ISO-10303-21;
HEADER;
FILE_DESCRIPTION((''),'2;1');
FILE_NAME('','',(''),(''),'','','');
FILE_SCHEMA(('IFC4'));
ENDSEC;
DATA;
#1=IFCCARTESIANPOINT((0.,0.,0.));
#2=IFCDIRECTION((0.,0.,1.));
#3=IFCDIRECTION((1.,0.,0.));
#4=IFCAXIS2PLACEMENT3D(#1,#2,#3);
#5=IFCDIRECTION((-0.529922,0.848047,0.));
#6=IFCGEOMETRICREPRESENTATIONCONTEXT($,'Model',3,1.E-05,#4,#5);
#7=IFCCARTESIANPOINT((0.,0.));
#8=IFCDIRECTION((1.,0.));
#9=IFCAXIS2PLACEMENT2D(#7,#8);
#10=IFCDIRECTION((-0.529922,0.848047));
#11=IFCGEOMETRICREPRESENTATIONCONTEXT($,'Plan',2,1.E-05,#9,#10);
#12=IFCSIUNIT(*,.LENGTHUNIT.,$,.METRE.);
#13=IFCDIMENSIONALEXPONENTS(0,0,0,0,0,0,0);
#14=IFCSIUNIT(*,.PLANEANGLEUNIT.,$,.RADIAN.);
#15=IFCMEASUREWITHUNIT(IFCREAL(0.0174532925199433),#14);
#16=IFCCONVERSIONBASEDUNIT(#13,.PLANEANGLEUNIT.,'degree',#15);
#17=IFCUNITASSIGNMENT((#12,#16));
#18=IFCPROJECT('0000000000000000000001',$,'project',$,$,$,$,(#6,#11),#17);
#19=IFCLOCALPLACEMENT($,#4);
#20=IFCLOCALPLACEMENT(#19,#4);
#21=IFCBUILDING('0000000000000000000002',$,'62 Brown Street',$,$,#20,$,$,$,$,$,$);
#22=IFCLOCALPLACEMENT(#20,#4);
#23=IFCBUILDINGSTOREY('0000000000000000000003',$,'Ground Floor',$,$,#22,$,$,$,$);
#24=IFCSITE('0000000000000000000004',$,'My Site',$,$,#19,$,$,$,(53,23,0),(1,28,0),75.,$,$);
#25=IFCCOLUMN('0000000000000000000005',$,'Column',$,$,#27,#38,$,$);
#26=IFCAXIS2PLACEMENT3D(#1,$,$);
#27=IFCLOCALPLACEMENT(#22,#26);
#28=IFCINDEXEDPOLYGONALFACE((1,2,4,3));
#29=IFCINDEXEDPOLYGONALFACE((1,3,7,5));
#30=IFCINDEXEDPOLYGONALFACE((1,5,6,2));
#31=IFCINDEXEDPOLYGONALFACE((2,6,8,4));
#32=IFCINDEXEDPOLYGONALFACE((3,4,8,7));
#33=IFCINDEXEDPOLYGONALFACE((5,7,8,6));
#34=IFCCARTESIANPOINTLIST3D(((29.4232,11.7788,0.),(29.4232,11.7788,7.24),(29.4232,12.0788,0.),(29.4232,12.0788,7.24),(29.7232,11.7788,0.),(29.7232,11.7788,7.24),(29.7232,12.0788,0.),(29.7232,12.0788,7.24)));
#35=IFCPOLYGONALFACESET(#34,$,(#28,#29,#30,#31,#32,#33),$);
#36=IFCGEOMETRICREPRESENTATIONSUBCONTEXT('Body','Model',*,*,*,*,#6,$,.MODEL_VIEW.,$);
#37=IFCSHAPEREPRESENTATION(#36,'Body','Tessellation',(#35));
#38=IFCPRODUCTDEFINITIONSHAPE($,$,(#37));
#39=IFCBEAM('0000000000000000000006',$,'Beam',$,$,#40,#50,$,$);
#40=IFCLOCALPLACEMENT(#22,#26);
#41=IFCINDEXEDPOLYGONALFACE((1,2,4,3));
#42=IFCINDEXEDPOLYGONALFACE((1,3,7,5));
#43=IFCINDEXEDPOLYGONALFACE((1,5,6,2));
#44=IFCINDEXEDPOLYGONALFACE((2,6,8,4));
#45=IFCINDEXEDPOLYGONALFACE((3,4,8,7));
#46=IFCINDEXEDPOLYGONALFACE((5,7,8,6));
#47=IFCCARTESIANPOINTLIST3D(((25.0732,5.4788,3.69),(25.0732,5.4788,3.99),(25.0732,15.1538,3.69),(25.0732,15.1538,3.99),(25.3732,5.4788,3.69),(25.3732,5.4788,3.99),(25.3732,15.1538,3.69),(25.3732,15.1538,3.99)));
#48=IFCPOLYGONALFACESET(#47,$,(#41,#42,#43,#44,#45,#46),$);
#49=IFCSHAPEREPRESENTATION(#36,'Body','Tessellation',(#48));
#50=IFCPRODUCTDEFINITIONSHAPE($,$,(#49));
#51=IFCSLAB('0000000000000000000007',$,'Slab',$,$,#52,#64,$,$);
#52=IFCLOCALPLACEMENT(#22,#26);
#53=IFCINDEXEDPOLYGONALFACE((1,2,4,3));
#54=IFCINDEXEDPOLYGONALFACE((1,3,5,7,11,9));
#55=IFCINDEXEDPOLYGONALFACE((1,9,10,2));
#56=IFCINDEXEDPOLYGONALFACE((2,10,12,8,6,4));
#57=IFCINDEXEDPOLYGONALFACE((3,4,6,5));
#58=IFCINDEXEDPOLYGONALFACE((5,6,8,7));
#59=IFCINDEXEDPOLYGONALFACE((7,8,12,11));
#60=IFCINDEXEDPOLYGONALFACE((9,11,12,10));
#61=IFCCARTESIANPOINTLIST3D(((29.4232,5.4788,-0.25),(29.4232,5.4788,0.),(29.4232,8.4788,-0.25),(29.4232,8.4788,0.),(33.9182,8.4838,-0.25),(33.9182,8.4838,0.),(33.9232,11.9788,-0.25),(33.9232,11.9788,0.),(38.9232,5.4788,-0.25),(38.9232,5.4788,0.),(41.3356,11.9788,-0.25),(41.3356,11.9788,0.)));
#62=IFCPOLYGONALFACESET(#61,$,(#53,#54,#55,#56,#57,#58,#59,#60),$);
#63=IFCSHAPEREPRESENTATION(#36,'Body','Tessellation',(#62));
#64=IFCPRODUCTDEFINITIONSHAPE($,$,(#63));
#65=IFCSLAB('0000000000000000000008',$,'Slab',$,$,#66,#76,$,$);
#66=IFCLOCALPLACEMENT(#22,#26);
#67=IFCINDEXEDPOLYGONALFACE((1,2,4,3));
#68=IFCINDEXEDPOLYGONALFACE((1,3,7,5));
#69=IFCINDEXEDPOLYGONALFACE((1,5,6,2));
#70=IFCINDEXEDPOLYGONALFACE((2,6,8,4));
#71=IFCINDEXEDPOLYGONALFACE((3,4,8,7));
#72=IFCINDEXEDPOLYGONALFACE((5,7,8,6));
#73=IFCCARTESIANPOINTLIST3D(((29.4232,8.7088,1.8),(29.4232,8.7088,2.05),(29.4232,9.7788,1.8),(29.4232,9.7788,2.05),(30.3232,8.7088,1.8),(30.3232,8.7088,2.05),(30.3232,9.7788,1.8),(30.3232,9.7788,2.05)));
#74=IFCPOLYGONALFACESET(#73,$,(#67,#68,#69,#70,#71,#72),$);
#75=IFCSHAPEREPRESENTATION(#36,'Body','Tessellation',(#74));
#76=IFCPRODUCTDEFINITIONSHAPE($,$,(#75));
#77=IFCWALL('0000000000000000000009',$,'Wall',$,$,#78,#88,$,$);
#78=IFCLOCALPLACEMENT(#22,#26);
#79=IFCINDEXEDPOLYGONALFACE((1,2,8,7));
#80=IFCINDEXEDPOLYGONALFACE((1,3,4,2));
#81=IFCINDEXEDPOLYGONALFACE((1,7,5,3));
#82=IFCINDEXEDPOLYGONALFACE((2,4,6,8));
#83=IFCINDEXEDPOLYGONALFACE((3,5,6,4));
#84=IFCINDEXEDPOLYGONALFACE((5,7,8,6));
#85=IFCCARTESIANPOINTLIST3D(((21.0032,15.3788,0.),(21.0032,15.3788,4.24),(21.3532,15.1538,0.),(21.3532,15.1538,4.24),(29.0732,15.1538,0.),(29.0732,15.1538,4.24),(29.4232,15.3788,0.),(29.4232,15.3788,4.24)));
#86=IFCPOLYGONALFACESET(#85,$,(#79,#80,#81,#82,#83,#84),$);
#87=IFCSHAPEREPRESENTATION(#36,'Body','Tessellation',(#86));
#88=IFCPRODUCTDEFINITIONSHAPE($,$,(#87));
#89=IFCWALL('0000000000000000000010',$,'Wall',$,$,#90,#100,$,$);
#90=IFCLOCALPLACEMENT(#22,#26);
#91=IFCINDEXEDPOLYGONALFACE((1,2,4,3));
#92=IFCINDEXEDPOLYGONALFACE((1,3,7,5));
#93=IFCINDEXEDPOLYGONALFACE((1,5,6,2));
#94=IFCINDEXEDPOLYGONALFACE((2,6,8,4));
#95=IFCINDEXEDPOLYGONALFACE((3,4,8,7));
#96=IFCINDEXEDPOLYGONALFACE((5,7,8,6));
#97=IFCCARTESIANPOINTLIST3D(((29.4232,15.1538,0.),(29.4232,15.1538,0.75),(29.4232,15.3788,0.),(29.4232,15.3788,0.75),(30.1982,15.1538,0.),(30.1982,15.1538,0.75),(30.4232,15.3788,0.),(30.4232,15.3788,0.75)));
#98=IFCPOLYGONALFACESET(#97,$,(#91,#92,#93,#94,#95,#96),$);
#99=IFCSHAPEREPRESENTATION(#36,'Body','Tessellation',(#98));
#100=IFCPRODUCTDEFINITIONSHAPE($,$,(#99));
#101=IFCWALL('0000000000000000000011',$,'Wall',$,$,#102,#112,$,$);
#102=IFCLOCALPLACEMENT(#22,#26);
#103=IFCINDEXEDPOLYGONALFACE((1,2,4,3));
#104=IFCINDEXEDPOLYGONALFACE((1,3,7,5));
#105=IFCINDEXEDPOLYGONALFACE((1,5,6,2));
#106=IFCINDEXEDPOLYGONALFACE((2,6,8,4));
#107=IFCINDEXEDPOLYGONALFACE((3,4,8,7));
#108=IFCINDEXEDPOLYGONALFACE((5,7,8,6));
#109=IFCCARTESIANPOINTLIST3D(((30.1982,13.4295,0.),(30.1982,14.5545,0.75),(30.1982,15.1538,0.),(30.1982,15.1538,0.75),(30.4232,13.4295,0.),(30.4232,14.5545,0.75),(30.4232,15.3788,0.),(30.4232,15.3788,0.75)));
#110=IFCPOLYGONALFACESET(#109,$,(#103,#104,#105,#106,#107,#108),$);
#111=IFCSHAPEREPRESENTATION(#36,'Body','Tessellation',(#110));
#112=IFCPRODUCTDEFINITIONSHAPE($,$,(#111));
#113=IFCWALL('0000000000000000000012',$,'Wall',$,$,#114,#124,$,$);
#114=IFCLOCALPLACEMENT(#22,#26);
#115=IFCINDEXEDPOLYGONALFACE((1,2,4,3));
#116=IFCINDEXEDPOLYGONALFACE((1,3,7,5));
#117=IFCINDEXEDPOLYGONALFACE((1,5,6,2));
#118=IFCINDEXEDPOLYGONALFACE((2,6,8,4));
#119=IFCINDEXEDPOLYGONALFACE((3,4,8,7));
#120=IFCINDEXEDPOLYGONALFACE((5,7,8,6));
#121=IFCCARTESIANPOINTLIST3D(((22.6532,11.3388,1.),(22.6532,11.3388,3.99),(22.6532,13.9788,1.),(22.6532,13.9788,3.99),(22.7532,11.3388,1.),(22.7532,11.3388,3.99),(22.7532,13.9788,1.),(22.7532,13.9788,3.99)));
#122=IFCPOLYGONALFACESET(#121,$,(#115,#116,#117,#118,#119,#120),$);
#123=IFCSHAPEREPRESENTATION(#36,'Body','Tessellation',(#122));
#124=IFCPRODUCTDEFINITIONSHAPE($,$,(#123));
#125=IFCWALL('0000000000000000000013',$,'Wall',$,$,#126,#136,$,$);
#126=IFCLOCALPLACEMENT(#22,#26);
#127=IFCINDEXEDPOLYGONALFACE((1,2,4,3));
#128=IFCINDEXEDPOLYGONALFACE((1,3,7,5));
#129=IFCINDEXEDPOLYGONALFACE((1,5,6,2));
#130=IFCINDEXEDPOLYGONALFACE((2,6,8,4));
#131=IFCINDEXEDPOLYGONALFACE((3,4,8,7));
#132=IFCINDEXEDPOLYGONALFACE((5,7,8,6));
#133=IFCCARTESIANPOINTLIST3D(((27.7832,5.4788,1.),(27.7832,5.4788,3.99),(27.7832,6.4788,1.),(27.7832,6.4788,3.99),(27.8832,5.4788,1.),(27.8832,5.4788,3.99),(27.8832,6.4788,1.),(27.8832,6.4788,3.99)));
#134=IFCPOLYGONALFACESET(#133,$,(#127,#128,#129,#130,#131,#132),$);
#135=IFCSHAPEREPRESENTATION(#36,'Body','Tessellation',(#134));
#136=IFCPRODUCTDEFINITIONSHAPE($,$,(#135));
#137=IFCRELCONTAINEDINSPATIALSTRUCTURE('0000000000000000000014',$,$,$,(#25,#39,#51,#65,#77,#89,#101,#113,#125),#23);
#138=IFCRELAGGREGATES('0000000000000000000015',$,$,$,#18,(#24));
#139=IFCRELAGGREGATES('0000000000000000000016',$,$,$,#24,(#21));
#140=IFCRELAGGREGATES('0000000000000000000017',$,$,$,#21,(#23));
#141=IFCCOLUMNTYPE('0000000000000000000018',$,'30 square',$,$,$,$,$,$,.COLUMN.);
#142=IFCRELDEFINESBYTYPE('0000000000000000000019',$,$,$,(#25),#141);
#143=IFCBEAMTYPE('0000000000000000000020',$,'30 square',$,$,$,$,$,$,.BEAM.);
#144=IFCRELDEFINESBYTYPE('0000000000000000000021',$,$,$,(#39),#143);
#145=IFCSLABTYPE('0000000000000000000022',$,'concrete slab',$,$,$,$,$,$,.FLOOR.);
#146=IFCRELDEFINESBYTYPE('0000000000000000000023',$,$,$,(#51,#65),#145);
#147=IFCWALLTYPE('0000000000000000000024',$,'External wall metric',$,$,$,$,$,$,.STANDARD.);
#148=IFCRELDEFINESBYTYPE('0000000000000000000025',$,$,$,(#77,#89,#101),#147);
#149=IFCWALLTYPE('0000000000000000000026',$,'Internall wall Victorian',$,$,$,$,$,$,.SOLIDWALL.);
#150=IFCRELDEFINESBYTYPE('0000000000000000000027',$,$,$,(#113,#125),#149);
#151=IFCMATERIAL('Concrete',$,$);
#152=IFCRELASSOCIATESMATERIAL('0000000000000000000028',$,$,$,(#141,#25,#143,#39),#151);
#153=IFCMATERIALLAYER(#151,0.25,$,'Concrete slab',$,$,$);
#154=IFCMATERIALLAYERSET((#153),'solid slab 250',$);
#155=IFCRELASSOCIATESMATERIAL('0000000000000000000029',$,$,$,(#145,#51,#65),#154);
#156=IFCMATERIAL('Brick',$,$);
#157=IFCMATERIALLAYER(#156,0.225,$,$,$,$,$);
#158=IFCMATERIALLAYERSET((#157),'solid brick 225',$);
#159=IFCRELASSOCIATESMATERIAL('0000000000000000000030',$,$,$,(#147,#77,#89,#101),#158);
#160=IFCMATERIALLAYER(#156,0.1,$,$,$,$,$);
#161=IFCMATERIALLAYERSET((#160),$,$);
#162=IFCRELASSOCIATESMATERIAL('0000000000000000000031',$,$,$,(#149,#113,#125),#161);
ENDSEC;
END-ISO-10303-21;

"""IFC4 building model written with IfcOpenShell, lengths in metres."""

from ifc_helpers import new_model, entity, si_unit, converted_unit, direction, frame, origin_with_axes, origin_2d_with_axis, place, context, subcontext, project, spatial, line, indexed_curve, rectangle, outline, extrude, clip, halfspace, material, layer, layer_set, layer_usage, material_profile, profile_set, profile_usage, type_object, element, save


model = new_model("IFC4")

# Units and contexts
model_context = context("Model", 3, precision=1e-05, world=origin_with_axes(), true_north=direction((-0.529922, 0.848047, 0.0)))
plan_context = context("Plan", 2, precision=1e-05, world=origin_2d_with_axis(), true_north=direction((-0.529922, 0.848047)))
body_context = subcontext(model_context, "Body", "Model", "MODEL_VIEW")
ifc_project = project(units=[si_unit("LENGTHUNIT", "METRE"), converted_unit("PLANEANGLEUNIT", "degree", entity("IfcReal", 0.0174532925199433), si_unit("PLANEANGLEUNIT", "RADIAN"), dimensions=[0, 0, 0, 0, 0, 0, 0])], contexts=[model_context, plan_context])

# Site, building, storey
site_placement = place(None, origin_with_axes())
site = spatial("IfcSite", under=ifc_project, at=site_placement, Name="My Site", RefLatitude=(53, 23, 0), RefLongitude=(1, 28, 0), RefElevation=75.0)
building_placement = place(site_placement, origin_with_axes())
building = spatial("IfcBuilding", under=site, at=building_placement, Name="62 Brown Street")
storey_placement = place(building_placement, origin_with_axes())
storey = spatial("IfcBuildingStorey", under=building, at=storey_placement, Name="Ground Floor")

# Column
ifc_material_1 = material(Name="Concrete")
ifc_material_profile_1 = material_profile(ifc_material_1, rectangle(XDim=0.3, YDim=0.3))
ifc_profile_set_1 = profile_set([ifc_material_profile_1])
ifc_profile_usage_1 = profile_usage(ifc_profile_set_1, cardinal=5)
column_type = type_object("IfcColumnType", Name="30 square", PredefinedType="COLUMN", material=ifc_profile_set_1)
column_1_placement = place(storey_placement, frame((29.5732, 11.9288, 0.0), z_axis=(0.0, 0.0, 1.0), x_axis=(1.0, 0.0, 0.0)))
element("IfcColumn", 1, at=column_1_placement, inside=storey, type_object=column_type, material=ifc_profile_usage_1, Name="Column", context=body_context, shape_type="SweptSolid", body=[
    extrude(rectangle(XDim=0.3, YDim=0.3), origin_with_axes(), (0.0, 0.0, 1.0), 7.24),
])

# Beam
ifc_material_profile_2 = material_profile(ifc_material_1, rectangle(XDim=0.3, YDim=0.3))
ifc_profile_set_2 = profile_set([ifc_material_profile_2])
ifc_profile_usage_2 = profile_usage(ifc_profile_set_2, cardinal=5)
beam_type = type_object("IfcBeamType", Name="30 square", PredefinedType="BEAM", material=ifc_profile_set_2)
beam_placement = place(storey_placement, frame((25.2232, 5.4788, 3.84), z_axis=(0.0, 1.0, 0.0), x_axis=(-1.0, 0.0, 0.0)))
element("IfcBeam", 2, at=beam_placement, inside=storey, type_object=beam_type, material=ifc_profile_usage_2, Name="Beam", context=body_context, shape_type="SweptSolid", body=[
    extrude(rectangle(XDim=0.3, YDim=0.3), origin_with_axes(), (0.0, 0.0, 1.0), 9.675),
])

# Slabs
ifc_layer_1 = layer(ifc_material_1, 0.25, Name="Concrete slab")
ifc_layer_set_1 = layer_set([ifc_layer_1], Name="solid slab 250")
ifc_layer_usage_1 = layer_usage(ifc_layer_set_1, "AXIS3", "POSITIVE", 0.0)
slab_type = type_object("IfcSlabType", Name="concrete slab", PredefinedType="FLOOR", material=ifc_layer_set_1)
slab_1_placement = place(storey_placement, frame((29.4232, 5.4788, -0.25), z_axis=(0.0, 0.0, 1.0), x_axis=(1.0, 0.0, 0.0)))
element("IfcSlab", 3, at=slab_1_placement, inside=storey, type_object=slab_type, material=ifc_layer_usage_1, Name="Slab", context=body_context, shape_type="SweptSolid", body=[
    extrude(outline(indexed_curve([(0.0, 0.0), (9.5, 0.0), (11.9124, 6.5), (0.0, 3.0), (4.5, 6.5), (4.495, 3.005)], segments=[line(1, 2), line(2, 3), line(3, 5), line(5, 6), line(6, 4), line(4, 1)], self_intersect=False)), None, (0.0, 0.0, 1.0), 0.25),
])
ifc_layer_usage_2 = layer_usage(ifc_layer_set_1, "AXIS3", "POSITIVE", 0.0)
slab_2_placement = place(storey_placement, frame((29.4232, 8.7088, 1.8), z_axis=(0.0, 0.0, 1.0), x_axis=(1.0, 0.0, 0.0)))
element("IfcSlab", 4, at=slab_2_placement, inside=storey, type_object=slab_type, material=ifc_layer_usage_2, Name="Slab", context=body_context, shape_type="SweptSolid", body=[
    extrude(outline(indexed_curve([(0.9, 1.07), (0.9, 0.0), (0.0, 0.0), (0.0, 1.07)], segments=[line(3, 2), line(2, 1), line(1, 4), line(4, 3)], self_intersect=False)), None, (0.0, 0.0, 1.0), 0.25),
])

# Walls
ifc_material_2 = material(Name="Brick")
ifc_layer_2 = layer(ifc_material_2, 0.225)
ifc_layer_set_2 = layer_set([ifc_layer_2], Name="solid brick 225")
wall_type_1 = type_object("IfcWallType", Name="External wall metric", PredefinedType="STANDARD", material=ifc_layer_set_2)
ifc_layer_usage_3 = layer_usage(ifc_layer_set_2, "AXIS2", "POSITIVE", 0.0)
wall_1_placement = place(storey_placement, frame((29.4232, 15.3788, 0.0), z_axis=(0.0, 0.0, 1.0), x_axis=(-1.0, 0.0, 0.0)))
element("IfcWall", 5, at=wall_1_placement, inside=storey, type_object=wall_type_1, material=ifc_layer_usage_3, Name="Wall", context=body_context, shape_type="Clipping", body=[
    clip(clip(extrude(outline(indexed_curve([(0.0, 0.0), (0.0, 0.225), (8.42, 0.225), (8.42, 0.0), (0.0, 0.0)], self_intersect=False)), origin_with_axes(), (0.0, 0.0, 1.0), 4.24), halfspace(frame((8.42, 0.0, 0.0), z_axis=(0.540756, 0.841179, 0.0), x_axis=(-0.841179, 0.540756, 0.0)), False)), halfspace(frame((0.0, 0.0, 0.0), z_axis=(-0.540758, 0.841178, 0.0), x_axis=(0.841178, 0.540758, 0.0)), False)),
])
ifc_layer_usage_4 = layer_usage(ifc_layer_set_2, "AXIS2", "POSITIVE", 0.0)
wall_2_placement = place(storey_placement, frame((30.4232, 15.3788, 0.0), z_axis=(0.0, 0.0, 1.0), x_axis=(-1.0, 0.0, 0.0)))
element("IfcWall", 6, at=wall_2_placement, inside=storey, type_object=wall_type_1, material=ifc_layer_usage_4, Name="Wall", context=body_context, shape_type="Clipping", body=[
    clip(extrude(outline(indexed_curve([(0.0, 0.0), (0.0, 0.225), (1.0, 0.225), (1.0, 0.0), (0.0, 0.0)], self_intersect=False)), origin_with_axes(), (0.0, 0.0, 1.0), 0.75), halfspace(frame((0.0, 0.0, 0.0), z_axis=(-0.707107, 0.707107, 0.0), x_axis=(0.707107, 0.707107, 0.0)), False)),
])
ifc_layer_usage_5 = layer_usage(ifc_layer_set_2, "AXIS2", "POSITIVE", 0.0)
wall_3_placement = place(storey_placement, frame((30.4232, 13.4295, 0.0), z_axis=(0.0, 0.0, 1.0), x_axis=(0.0, 1.0, 0.0)))
element("IfcWall", 7, at=wall_3_placement, inside=storey, type_object=wall_type_1, material=ifc_layer_usage_5, Name="Wall", context=body_context, shape_type="Clipping", body=[
    clip(clip(extrude(outline(indexed_curve([(0.0, 0.0), (0.0, 0.225), (1.9493, 0.225), (1.9493, 0.0), (0.0, 0.0)], self_intersect=False)), origin_with_axes(), (0.0, 0.0, 1.0), 0.75), halfspace(frame((0.416, 0.5, 0.2774), z_axis=(-0.5547, 0.0, 0.83205), x_axis=(0.0, -1.0, 0.0)), False)), halfspace(frame((1.9493, 0.0, 0.0), z_axis=(0.707107, 0.707107, 0.0), x_axis=(0.707107, -0.707107, 0.0)), False)),
])
ifc_layer_3 = layer(ifc_material_2, 0.1)
ifc_layer_set_3 = layer_set([ifc_layer_3])
ifc_layer_usage_6 = layer_usage(ifc_layer_set_3, "AXIS2", "POSITIVE", 0.0)
wall_type_2 = type_object("IfcWallType", Name="Internall wall Victorian", PredefinedType="SOLIDWALL", material=ifc_layer_set_3)
wall_4_placement = place(storey_placement, frame((22.7532, 11.3388, 1.0), z_axis=(0.0, 0.0, 1.0), x_axis=(0.0, 1.0, 0.0)))
element("IfcWall", 8, at=wall_4_placement, inside=storey, type_object=wall_type_2, material=ifc_layer_usage_6, Name="Wall", context=body_context, shape_type="SweptSolid", body=[
    extrude(outline(indexed_curve([(0.0, 0.0), (0.0, 0.1), (2.64, 0.1), (2.64, 0.0), (0.0, 0.0)], self_intersect=False)), origin_with_axes(), (0.0, 0.0, 1.0), 2.99),
])
ifc_layer_usage_7 = layer_usage(ifc_layer_set_3, "AXIS2", "POSITIVE", 0.0)
wall_5_placement = place(storey_placement, frame((27.8832, 5.4788, 1.0), z_axis=(0.0, 0.0, 1.0), x_axis=(0.0, 1.0, 0.0)))
element("IfcWall", 9, at=wall_5_placement, inside=storey, type_object=wall_type_2, material=ifc_layer_usage_7, Name="Wall", context=body_context, shape_type="SweptSolid", body=[
    extrude(outline(indexed_curve([(0.0, 0.0), (0.0, 0.1), (1.0, 0.1), (1.0, 0.0), (0.0, 0.0)], self_intersect=False)), origin_with_axes(), (0.0, 0.0, 1.0), 2.99),
])

save(model, "model.ifc")
